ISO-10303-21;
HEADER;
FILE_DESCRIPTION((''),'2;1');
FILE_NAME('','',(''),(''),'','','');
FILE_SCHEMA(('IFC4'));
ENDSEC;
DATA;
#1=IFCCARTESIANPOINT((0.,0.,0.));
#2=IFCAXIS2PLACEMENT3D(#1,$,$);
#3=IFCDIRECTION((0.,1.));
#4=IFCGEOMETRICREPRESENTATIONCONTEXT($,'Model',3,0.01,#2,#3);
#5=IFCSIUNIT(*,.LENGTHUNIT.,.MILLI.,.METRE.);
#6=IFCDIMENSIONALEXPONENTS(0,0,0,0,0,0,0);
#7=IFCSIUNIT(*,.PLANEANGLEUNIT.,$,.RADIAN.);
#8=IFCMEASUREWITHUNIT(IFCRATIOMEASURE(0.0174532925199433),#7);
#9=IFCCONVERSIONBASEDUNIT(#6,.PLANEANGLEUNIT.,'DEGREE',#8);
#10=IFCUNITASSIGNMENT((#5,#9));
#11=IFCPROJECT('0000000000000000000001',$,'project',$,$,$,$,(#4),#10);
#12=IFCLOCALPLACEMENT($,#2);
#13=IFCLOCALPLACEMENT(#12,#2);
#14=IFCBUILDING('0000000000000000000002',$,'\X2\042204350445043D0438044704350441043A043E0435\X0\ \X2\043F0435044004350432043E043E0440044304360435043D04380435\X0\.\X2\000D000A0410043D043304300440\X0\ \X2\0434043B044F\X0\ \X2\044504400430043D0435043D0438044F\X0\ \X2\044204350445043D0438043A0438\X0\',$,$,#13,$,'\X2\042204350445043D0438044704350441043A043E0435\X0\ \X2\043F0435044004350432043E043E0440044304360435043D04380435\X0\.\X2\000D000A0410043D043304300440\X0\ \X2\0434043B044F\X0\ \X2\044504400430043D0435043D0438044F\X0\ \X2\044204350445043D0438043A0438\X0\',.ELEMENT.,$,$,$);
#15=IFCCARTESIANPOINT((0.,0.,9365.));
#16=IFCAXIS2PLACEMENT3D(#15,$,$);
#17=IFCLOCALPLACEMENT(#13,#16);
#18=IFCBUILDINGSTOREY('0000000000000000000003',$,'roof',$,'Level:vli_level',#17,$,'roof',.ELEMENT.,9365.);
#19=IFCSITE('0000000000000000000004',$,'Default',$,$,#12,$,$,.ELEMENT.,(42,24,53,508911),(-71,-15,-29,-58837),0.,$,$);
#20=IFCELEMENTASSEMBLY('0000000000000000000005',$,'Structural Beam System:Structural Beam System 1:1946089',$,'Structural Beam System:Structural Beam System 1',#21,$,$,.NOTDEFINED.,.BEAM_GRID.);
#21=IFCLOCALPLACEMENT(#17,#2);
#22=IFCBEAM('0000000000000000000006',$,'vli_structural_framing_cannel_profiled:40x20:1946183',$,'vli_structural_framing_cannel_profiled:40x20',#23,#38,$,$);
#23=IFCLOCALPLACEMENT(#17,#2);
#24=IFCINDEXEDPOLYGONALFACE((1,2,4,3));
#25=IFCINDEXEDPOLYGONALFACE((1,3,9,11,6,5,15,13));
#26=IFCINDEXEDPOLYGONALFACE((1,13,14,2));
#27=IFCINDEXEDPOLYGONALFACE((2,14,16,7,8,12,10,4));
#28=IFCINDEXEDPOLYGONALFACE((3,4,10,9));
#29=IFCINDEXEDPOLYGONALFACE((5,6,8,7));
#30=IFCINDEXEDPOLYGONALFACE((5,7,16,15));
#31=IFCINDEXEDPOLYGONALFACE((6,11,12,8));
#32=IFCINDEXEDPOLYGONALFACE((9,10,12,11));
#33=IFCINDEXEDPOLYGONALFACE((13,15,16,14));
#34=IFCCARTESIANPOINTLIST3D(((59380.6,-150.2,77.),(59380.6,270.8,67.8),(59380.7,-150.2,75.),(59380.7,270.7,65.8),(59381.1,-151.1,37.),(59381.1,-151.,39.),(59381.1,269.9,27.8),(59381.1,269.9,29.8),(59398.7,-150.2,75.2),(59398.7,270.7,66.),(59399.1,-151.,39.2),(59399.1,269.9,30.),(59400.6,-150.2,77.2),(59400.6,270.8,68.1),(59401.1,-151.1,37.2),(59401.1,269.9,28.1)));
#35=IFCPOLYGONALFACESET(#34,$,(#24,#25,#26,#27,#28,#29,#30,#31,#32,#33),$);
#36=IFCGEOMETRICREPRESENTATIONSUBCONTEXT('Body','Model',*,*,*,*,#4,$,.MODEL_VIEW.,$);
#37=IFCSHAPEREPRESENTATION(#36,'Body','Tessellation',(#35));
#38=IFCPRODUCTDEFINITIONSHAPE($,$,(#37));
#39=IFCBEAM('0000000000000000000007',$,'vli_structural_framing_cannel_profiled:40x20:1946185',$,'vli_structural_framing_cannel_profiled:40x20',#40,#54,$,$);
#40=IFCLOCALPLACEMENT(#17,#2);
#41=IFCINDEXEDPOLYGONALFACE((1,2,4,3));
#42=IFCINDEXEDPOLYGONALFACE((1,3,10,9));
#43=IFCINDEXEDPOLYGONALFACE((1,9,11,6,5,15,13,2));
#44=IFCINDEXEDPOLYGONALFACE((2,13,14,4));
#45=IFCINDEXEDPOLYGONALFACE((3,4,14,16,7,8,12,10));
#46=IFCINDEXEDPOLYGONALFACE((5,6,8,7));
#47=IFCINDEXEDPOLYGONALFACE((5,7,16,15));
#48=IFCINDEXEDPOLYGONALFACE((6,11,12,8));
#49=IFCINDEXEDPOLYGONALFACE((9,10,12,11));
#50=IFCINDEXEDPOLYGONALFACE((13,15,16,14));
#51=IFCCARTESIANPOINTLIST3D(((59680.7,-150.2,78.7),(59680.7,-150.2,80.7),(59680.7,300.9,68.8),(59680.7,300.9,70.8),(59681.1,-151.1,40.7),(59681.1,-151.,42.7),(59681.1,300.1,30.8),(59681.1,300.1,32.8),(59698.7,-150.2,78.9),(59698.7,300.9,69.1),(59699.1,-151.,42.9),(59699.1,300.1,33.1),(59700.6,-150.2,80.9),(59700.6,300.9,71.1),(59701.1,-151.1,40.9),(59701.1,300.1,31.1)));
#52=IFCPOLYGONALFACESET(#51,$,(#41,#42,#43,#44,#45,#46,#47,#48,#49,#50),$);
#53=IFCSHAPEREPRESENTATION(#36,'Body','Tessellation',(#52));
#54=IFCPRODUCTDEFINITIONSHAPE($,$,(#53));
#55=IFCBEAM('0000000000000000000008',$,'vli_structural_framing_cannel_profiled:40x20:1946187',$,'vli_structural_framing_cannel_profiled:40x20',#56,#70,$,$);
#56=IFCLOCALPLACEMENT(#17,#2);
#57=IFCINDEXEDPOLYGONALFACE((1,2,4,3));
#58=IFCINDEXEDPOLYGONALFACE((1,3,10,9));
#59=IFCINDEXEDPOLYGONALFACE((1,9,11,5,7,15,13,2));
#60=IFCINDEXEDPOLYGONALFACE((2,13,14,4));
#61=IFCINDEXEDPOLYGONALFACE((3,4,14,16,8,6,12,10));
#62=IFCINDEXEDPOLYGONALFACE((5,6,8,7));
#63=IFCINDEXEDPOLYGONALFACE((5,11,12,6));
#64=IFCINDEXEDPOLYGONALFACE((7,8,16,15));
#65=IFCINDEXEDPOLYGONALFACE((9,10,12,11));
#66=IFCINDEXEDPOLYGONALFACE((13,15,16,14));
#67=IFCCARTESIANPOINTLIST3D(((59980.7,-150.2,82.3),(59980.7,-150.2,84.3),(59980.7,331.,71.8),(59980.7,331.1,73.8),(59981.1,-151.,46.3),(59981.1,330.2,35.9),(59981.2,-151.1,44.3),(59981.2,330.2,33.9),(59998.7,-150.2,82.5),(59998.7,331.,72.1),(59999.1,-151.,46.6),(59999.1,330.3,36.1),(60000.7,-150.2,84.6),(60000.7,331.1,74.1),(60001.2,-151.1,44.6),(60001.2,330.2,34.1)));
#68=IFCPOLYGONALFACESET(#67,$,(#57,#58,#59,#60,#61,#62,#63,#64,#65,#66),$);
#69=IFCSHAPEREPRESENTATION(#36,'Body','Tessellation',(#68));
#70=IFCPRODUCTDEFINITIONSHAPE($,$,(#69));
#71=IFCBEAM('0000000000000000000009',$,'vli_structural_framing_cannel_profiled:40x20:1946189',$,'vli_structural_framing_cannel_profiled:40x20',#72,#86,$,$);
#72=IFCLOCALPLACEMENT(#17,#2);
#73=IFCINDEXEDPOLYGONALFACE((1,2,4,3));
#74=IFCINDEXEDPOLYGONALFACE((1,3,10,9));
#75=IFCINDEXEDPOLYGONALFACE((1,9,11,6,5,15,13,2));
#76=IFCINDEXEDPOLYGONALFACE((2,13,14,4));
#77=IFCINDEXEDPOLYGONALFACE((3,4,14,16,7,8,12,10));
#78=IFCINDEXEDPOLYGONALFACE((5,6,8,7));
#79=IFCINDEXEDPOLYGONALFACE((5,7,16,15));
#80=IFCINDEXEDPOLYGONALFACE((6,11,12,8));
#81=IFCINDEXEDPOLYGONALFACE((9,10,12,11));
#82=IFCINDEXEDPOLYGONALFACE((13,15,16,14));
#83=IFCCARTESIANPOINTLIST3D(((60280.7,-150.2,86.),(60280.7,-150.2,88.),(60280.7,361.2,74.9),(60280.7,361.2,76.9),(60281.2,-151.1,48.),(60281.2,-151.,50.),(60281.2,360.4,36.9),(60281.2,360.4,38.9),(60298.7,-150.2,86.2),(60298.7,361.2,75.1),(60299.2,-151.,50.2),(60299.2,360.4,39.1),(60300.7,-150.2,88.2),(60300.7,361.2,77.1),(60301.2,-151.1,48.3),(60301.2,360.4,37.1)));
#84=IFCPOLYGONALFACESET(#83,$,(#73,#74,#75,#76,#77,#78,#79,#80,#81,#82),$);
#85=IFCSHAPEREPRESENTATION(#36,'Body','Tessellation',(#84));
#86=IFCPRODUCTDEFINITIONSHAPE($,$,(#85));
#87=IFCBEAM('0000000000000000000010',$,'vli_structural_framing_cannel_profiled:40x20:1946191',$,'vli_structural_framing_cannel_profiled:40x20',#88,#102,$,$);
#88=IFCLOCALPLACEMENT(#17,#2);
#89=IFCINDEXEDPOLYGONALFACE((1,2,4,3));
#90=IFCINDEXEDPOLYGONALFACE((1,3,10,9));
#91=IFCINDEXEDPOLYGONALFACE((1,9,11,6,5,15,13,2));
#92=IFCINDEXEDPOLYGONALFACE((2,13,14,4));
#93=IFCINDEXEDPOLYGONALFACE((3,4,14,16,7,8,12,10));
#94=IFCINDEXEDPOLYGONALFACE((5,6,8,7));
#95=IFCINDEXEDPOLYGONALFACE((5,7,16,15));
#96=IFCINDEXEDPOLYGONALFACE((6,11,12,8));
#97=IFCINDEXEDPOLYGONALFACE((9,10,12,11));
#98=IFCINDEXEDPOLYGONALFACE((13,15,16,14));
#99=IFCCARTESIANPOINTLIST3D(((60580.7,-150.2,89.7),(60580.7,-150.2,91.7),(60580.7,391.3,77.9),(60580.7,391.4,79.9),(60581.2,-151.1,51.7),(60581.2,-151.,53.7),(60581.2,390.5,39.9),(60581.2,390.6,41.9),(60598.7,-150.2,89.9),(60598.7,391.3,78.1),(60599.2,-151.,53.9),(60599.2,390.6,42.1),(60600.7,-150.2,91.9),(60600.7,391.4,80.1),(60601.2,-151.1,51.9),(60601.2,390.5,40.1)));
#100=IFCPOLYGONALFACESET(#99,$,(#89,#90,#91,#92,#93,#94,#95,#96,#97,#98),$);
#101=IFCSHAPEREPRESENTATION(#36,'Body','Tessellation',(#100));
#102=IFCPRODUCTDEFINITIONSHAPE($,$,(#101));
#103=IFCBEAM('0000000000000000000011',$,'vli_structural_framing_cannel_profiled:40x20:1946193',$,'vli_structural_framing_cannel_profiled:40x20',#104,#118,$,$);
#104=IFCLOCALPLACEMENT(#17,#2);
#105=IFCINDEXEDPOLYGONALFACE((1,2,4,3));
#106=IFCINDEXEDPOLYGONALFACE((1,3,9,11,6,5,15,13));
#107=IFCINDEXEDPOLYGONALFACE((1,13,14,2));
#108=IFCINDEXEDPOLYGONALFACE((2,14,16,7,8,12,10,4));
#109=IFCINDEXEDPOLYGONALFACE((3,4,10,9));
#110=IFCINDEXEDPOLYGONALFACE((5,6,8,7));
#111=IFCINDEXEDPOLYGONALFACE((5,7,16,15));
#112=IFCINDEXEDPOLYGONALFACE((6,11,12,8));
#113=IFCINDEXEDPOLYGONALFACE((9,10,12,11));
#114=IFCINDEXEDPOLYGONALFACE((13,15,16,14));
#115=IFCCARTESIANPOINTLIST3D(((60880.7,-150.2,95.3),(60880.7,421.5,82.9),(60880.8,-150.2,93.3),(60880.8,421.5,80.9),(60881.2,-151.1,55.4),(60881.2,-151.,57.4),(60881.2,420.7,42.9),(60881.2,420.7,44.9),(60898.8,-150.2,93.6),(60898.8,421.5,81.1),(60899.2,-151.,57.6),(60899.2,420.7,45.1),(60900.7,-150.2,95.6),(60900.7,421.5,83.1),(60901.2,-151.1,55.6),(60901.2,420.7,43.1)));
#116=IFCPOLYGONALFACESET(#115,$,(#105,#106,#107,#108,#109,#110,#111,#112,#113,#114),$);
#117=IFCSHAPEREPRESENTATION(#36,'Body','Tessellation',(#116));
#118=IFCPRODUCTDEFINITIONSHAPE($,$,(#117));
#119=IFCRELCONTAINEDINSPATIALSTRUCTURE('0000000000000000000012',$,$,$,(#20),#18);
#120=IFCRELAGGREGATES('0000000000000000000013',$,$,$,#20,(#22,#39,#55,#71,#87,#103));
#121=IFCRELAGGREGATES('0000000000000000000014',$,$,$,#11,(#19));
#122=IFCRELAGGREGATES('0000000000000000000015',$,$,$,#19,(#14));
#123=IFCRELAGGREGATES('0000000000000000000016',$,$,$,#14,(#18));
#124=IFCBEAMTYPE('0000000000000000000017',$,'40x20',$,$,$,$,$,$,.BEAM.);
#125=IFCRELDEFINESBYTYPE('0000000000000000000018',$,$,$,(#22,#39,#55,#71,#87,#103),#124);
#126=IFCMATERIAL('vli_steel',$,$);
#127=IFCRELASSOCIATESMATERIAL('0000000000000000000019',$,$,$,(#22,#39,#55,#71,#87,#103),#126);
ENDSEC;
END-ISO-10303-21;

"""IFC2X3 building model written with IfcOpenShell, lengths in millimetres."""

from ifc_helpers import new_model, entity, si_unit, converted_unit, direction, frame, origin, place, context, subcontext, project, spatial, polyline, outline, extrude, material, type_object, element, aggregate, save


model = new_model("IFC2X3")

# Units and contexts
model_context = context("Model", 3, precision=0.01, world=origin(), true_north=direction((0.0, 1.0)))
body_context = subcontext(model_context, "Body", "Model", "MODEL_VIEW")
ifc_project = project(units=[si_unit("LENGTHUNIT", "METRE", prefix="MILLI"), converted_unit("PLANEANGLEUNIT", "DEGREE", entity("IfcRatioMeasure", 0.0174532925199433), si_unit("PLANEANGLEUNIT", "RADIAN"), dimensions=[0, 0, 0, 0, 0, 0, 0])], contexts=[model_context])

# Site, building, storey
site_placement = place(None, origin())
site = spatial("IfcSite", under=ifc_project, at=site_placement, Name="Default", CompositionType="ELEMENT", RefLatitude=(42, 24, 53, 508911), RefLongitude=(-71, -15, -29, -58837), RefElevation=0.0)
building_placement = place(site_placement, origin())
building = spatial("IfcBuilding", under=site, at=building_placement, Name="Техническое перевооружение.\r\nАнгар для хранения техники", LongName="Техническое перевооружение.\r\nАнгар для хранения техники", CompositionType="ELEMENT")
storey_placement = place(building_placement, frame((0.0, 0.0, 9365.0)))
storey = spatial("IfcBuildingStorey", under=building, at=storey_placement, Name="roof", ObjectType="Level:vli_level", LongName="roof", CompositionType="ELEMENT", Elevation=9365.0)

# Shared definitions
ifc_material = material(Name="vli_steel")
beam_type = type_object("IfcBeamType", Name="40x20", PredefinedType="BEAM")

# Element assembly, beams
assembly_1_placement = place(storey_placement, origin())
assembly_1 = element("IfcElementAssembly", 1, at=assembly_1_placement, inside=storey, Name="Structural Beam System:Structural Beam System 1:1946089", ObjectType="Structural Beam System:Structural Beam System 1", AssemblyPlace="NOTDEFINED", PredefinedType="BEAM_GRID")
beam_1_placement = place(assembly_1_placement, frame((59400.0, 270.8, 68.1), z_axis=(0.0, 0.021775, 0.999763), x_axis=(0.0, -0.999763, 0.021775)))
beam_1 = element("IfcBeam", 2, at=beam_1_placement, type_object=beam_type, material=ifc_material, Name="vli_structural_framing_cannel_profiled:40x20:1946183", ObjectType="vli_structural_framing_cannel_profiled:40x20", context=body_context, shape_type="SweptSolid", body=[
    extrude(outline(polyline([(-10.5, -20.0), (9.5, -20.0), (9.5, -18.0), (-8.5, -18.0), (-8.5, 18.0), (9.5, 18.0), (9.5, 20.0), (-10.5, 20.0), (-10.5, -20.0)])), frame((0.0, -9.7, -20.1), z_axis=(1.0, 0.0, 0.0), x_axis=(0.0, -0.999925, -0.01227)), (0.0, 0.0, 1.0), 421.1),
])
beam_2_placement = place(assembly_1_placement, frame((59700.0, 300.9, 71.1), z_axis=(0.0, 0.021775, 0.999763), x_axis=(0.0, -0.999763, 0.021775)))
beam_2 = element("IfcBeam", 3, at=beam_2_placement, type_object=beam_type, material=ifc_material, Name="vli_structural_framing_cannel_profiled:40x20:1946185", ObjectType="vli_structural_framing_cannel_profiled:40x20", context=body_context, shape_type="SweptSolid", body=[
    extrude(outline(polyline([(-10.5, -20.0), (9.5, -20.0), (9.5, -18.0), (-8.5, -18.0), (-8.5, 18.0), (9.5, 18.0), (9.5, 20.0), (-10.5, 20.0), (-10.5, -20.0)])), frame((0.0, -9.7, -20.1), z_axis=(1.0, 0.0, 0.0), x_axis=(0.0, -0.999925, -0.01227)), (0.0, 0.0, 1.0), 451.2),
])
beam_3_placement = place(assembly_1_placement, frame((60000.1, 331.1, 74.1), z_axis=(0.0, 0.021775, 0.999763), x_axis=(0.0, -0.999763, 0.021775)))
beam_3 = element("IfcBeam", 4, at=beam_3_placement, type_object=beam_type, material=ifc_material, Name="vli_structural_framing_cannel_profiled:40x20:1946187", ObjectType="vli_structural_framing_cannel_profiled:40x20", context=body_context, shape_type="SweptSolid", body=[
    extrude(outline(polyline([(-10.5, -20.0), (9.5, -20.0), (9.5, -18.0), (-8.5, -18.0), (-8.5, 18.0), (9.5, 18.0), (9.5, 20.0), (-10.5, 20.0), (-10.5, -20.0)])), frame((0.0, -9.7, -20.1), z_axis=(1.0, 0.0, 0.0), x_axis=(0.0, -0.999925, -0.01227)), (0.0, 0.0, 1.0), 481.4),
])
beam_4_placement = place(assembly_1_placement, frame((60300.1, 361.2, 77.1), z_axis=(0.0, 0.021775, 0.999763), x_axis=(0.0, -0.999763, 0.021775)))
beam_4 = element("IfcBeam", 5, at=beam_4_placement, type_object=beam_type, material=ifc_material, Name="vli_structural_framing_cannel_profiled:40x20:1946189", ObjectType="vli_structural_framing_cannel_profiled:40x20", context=body_context, shape_type="SweptSolid", body=[
    extrude(outline(polyline([(-10.5, -20.0), (9.5, -20.0), (9.5, -18.0), (-8.5, -18.0), (-8.5, 18.0), (9.5, 18.0), (9.5, 20.0), (-10.5, 20.0), (-10.5, -20.0)])), frame((0.0, -9.7, -20.1), z_axis=(1.0, 0.0, 0.0), x_axis=(0.0, -0.999925, -0.01227)), (0.0, 0.0, 1.0), 511.5),
])
beam_5_placement = place(assembly_1_placement, frame((60600.1, 391.4, 80.1), z_axis=(0.0, 0.021775, 0.999763), x_axis=(0.0, -0.999763, 0.021775)))
beam_5 = element("IfcBeam", 6, at=beam_5_placement, type_object=beam_type, material=ifc_material, Name="vli_structural_framing_cannel_profiled:40x20:1946191", ObjectType="vli_structural_framing_cannel_profiled:40x20", context=body_context, shape_type="SweptSolid", body=[
    extrude(outline(polyline([(-10.5, -20.0), (9.5, -20.0), (9.5, -18.0), (-8.5, -18.0), (-8.5, 18.0), (9.5, 18.0), (9.5, 20.0), (-10.5, 20.0), (-10.5, -20.0)])), frame((0.0, -9.7, -20.1), z_axis=(1.0, 0.0, 0.0), x_axis=(0.0, -0.999925, -0.01227)), (0.0, 0.0, 1.0), 541.7),
])
beam_6_placement = place(assembly_1_placement, frame((60900.1, 421.5, 83.1), z_axis=(0.0, 0.021775, 0.999763), x_axis=(0.0, -0.999763, 0.021775)))
beam_6 = element("IfcBeam", 7, at=beam_6_placement, type_object=beam_type, material=ifc_material, Name="vli_structural_framing_cannel_profiled:40x20:1946193", ObjectType="vli_structural_framing_cannel_profiled:40x20", context=body_context, shape_type="SweptSolid", body=[
    extrude(outline(polyline([(-10.5, -20.0), (9.5, -20.0), (9.5, -18.0), (-8.5, -18.0), (-8.5, 18.0), (9.5, 18.0), (9.5, 20.0), (-10.5, 20.0), (-10.5, -20.0)])), frame((0.0, -9.7, -20.1), z_axis=(1.0, 0.0, 0.0), x_axis=(0.0, -0.999925, -0.01227)), (0.0, 0.0, 1.0), 571.9),
])
aggregate(assembly_1, [beam_1, beam_2, beam_3, beam_4, beam_5, beam_6])

save(model, "model.ifc")
